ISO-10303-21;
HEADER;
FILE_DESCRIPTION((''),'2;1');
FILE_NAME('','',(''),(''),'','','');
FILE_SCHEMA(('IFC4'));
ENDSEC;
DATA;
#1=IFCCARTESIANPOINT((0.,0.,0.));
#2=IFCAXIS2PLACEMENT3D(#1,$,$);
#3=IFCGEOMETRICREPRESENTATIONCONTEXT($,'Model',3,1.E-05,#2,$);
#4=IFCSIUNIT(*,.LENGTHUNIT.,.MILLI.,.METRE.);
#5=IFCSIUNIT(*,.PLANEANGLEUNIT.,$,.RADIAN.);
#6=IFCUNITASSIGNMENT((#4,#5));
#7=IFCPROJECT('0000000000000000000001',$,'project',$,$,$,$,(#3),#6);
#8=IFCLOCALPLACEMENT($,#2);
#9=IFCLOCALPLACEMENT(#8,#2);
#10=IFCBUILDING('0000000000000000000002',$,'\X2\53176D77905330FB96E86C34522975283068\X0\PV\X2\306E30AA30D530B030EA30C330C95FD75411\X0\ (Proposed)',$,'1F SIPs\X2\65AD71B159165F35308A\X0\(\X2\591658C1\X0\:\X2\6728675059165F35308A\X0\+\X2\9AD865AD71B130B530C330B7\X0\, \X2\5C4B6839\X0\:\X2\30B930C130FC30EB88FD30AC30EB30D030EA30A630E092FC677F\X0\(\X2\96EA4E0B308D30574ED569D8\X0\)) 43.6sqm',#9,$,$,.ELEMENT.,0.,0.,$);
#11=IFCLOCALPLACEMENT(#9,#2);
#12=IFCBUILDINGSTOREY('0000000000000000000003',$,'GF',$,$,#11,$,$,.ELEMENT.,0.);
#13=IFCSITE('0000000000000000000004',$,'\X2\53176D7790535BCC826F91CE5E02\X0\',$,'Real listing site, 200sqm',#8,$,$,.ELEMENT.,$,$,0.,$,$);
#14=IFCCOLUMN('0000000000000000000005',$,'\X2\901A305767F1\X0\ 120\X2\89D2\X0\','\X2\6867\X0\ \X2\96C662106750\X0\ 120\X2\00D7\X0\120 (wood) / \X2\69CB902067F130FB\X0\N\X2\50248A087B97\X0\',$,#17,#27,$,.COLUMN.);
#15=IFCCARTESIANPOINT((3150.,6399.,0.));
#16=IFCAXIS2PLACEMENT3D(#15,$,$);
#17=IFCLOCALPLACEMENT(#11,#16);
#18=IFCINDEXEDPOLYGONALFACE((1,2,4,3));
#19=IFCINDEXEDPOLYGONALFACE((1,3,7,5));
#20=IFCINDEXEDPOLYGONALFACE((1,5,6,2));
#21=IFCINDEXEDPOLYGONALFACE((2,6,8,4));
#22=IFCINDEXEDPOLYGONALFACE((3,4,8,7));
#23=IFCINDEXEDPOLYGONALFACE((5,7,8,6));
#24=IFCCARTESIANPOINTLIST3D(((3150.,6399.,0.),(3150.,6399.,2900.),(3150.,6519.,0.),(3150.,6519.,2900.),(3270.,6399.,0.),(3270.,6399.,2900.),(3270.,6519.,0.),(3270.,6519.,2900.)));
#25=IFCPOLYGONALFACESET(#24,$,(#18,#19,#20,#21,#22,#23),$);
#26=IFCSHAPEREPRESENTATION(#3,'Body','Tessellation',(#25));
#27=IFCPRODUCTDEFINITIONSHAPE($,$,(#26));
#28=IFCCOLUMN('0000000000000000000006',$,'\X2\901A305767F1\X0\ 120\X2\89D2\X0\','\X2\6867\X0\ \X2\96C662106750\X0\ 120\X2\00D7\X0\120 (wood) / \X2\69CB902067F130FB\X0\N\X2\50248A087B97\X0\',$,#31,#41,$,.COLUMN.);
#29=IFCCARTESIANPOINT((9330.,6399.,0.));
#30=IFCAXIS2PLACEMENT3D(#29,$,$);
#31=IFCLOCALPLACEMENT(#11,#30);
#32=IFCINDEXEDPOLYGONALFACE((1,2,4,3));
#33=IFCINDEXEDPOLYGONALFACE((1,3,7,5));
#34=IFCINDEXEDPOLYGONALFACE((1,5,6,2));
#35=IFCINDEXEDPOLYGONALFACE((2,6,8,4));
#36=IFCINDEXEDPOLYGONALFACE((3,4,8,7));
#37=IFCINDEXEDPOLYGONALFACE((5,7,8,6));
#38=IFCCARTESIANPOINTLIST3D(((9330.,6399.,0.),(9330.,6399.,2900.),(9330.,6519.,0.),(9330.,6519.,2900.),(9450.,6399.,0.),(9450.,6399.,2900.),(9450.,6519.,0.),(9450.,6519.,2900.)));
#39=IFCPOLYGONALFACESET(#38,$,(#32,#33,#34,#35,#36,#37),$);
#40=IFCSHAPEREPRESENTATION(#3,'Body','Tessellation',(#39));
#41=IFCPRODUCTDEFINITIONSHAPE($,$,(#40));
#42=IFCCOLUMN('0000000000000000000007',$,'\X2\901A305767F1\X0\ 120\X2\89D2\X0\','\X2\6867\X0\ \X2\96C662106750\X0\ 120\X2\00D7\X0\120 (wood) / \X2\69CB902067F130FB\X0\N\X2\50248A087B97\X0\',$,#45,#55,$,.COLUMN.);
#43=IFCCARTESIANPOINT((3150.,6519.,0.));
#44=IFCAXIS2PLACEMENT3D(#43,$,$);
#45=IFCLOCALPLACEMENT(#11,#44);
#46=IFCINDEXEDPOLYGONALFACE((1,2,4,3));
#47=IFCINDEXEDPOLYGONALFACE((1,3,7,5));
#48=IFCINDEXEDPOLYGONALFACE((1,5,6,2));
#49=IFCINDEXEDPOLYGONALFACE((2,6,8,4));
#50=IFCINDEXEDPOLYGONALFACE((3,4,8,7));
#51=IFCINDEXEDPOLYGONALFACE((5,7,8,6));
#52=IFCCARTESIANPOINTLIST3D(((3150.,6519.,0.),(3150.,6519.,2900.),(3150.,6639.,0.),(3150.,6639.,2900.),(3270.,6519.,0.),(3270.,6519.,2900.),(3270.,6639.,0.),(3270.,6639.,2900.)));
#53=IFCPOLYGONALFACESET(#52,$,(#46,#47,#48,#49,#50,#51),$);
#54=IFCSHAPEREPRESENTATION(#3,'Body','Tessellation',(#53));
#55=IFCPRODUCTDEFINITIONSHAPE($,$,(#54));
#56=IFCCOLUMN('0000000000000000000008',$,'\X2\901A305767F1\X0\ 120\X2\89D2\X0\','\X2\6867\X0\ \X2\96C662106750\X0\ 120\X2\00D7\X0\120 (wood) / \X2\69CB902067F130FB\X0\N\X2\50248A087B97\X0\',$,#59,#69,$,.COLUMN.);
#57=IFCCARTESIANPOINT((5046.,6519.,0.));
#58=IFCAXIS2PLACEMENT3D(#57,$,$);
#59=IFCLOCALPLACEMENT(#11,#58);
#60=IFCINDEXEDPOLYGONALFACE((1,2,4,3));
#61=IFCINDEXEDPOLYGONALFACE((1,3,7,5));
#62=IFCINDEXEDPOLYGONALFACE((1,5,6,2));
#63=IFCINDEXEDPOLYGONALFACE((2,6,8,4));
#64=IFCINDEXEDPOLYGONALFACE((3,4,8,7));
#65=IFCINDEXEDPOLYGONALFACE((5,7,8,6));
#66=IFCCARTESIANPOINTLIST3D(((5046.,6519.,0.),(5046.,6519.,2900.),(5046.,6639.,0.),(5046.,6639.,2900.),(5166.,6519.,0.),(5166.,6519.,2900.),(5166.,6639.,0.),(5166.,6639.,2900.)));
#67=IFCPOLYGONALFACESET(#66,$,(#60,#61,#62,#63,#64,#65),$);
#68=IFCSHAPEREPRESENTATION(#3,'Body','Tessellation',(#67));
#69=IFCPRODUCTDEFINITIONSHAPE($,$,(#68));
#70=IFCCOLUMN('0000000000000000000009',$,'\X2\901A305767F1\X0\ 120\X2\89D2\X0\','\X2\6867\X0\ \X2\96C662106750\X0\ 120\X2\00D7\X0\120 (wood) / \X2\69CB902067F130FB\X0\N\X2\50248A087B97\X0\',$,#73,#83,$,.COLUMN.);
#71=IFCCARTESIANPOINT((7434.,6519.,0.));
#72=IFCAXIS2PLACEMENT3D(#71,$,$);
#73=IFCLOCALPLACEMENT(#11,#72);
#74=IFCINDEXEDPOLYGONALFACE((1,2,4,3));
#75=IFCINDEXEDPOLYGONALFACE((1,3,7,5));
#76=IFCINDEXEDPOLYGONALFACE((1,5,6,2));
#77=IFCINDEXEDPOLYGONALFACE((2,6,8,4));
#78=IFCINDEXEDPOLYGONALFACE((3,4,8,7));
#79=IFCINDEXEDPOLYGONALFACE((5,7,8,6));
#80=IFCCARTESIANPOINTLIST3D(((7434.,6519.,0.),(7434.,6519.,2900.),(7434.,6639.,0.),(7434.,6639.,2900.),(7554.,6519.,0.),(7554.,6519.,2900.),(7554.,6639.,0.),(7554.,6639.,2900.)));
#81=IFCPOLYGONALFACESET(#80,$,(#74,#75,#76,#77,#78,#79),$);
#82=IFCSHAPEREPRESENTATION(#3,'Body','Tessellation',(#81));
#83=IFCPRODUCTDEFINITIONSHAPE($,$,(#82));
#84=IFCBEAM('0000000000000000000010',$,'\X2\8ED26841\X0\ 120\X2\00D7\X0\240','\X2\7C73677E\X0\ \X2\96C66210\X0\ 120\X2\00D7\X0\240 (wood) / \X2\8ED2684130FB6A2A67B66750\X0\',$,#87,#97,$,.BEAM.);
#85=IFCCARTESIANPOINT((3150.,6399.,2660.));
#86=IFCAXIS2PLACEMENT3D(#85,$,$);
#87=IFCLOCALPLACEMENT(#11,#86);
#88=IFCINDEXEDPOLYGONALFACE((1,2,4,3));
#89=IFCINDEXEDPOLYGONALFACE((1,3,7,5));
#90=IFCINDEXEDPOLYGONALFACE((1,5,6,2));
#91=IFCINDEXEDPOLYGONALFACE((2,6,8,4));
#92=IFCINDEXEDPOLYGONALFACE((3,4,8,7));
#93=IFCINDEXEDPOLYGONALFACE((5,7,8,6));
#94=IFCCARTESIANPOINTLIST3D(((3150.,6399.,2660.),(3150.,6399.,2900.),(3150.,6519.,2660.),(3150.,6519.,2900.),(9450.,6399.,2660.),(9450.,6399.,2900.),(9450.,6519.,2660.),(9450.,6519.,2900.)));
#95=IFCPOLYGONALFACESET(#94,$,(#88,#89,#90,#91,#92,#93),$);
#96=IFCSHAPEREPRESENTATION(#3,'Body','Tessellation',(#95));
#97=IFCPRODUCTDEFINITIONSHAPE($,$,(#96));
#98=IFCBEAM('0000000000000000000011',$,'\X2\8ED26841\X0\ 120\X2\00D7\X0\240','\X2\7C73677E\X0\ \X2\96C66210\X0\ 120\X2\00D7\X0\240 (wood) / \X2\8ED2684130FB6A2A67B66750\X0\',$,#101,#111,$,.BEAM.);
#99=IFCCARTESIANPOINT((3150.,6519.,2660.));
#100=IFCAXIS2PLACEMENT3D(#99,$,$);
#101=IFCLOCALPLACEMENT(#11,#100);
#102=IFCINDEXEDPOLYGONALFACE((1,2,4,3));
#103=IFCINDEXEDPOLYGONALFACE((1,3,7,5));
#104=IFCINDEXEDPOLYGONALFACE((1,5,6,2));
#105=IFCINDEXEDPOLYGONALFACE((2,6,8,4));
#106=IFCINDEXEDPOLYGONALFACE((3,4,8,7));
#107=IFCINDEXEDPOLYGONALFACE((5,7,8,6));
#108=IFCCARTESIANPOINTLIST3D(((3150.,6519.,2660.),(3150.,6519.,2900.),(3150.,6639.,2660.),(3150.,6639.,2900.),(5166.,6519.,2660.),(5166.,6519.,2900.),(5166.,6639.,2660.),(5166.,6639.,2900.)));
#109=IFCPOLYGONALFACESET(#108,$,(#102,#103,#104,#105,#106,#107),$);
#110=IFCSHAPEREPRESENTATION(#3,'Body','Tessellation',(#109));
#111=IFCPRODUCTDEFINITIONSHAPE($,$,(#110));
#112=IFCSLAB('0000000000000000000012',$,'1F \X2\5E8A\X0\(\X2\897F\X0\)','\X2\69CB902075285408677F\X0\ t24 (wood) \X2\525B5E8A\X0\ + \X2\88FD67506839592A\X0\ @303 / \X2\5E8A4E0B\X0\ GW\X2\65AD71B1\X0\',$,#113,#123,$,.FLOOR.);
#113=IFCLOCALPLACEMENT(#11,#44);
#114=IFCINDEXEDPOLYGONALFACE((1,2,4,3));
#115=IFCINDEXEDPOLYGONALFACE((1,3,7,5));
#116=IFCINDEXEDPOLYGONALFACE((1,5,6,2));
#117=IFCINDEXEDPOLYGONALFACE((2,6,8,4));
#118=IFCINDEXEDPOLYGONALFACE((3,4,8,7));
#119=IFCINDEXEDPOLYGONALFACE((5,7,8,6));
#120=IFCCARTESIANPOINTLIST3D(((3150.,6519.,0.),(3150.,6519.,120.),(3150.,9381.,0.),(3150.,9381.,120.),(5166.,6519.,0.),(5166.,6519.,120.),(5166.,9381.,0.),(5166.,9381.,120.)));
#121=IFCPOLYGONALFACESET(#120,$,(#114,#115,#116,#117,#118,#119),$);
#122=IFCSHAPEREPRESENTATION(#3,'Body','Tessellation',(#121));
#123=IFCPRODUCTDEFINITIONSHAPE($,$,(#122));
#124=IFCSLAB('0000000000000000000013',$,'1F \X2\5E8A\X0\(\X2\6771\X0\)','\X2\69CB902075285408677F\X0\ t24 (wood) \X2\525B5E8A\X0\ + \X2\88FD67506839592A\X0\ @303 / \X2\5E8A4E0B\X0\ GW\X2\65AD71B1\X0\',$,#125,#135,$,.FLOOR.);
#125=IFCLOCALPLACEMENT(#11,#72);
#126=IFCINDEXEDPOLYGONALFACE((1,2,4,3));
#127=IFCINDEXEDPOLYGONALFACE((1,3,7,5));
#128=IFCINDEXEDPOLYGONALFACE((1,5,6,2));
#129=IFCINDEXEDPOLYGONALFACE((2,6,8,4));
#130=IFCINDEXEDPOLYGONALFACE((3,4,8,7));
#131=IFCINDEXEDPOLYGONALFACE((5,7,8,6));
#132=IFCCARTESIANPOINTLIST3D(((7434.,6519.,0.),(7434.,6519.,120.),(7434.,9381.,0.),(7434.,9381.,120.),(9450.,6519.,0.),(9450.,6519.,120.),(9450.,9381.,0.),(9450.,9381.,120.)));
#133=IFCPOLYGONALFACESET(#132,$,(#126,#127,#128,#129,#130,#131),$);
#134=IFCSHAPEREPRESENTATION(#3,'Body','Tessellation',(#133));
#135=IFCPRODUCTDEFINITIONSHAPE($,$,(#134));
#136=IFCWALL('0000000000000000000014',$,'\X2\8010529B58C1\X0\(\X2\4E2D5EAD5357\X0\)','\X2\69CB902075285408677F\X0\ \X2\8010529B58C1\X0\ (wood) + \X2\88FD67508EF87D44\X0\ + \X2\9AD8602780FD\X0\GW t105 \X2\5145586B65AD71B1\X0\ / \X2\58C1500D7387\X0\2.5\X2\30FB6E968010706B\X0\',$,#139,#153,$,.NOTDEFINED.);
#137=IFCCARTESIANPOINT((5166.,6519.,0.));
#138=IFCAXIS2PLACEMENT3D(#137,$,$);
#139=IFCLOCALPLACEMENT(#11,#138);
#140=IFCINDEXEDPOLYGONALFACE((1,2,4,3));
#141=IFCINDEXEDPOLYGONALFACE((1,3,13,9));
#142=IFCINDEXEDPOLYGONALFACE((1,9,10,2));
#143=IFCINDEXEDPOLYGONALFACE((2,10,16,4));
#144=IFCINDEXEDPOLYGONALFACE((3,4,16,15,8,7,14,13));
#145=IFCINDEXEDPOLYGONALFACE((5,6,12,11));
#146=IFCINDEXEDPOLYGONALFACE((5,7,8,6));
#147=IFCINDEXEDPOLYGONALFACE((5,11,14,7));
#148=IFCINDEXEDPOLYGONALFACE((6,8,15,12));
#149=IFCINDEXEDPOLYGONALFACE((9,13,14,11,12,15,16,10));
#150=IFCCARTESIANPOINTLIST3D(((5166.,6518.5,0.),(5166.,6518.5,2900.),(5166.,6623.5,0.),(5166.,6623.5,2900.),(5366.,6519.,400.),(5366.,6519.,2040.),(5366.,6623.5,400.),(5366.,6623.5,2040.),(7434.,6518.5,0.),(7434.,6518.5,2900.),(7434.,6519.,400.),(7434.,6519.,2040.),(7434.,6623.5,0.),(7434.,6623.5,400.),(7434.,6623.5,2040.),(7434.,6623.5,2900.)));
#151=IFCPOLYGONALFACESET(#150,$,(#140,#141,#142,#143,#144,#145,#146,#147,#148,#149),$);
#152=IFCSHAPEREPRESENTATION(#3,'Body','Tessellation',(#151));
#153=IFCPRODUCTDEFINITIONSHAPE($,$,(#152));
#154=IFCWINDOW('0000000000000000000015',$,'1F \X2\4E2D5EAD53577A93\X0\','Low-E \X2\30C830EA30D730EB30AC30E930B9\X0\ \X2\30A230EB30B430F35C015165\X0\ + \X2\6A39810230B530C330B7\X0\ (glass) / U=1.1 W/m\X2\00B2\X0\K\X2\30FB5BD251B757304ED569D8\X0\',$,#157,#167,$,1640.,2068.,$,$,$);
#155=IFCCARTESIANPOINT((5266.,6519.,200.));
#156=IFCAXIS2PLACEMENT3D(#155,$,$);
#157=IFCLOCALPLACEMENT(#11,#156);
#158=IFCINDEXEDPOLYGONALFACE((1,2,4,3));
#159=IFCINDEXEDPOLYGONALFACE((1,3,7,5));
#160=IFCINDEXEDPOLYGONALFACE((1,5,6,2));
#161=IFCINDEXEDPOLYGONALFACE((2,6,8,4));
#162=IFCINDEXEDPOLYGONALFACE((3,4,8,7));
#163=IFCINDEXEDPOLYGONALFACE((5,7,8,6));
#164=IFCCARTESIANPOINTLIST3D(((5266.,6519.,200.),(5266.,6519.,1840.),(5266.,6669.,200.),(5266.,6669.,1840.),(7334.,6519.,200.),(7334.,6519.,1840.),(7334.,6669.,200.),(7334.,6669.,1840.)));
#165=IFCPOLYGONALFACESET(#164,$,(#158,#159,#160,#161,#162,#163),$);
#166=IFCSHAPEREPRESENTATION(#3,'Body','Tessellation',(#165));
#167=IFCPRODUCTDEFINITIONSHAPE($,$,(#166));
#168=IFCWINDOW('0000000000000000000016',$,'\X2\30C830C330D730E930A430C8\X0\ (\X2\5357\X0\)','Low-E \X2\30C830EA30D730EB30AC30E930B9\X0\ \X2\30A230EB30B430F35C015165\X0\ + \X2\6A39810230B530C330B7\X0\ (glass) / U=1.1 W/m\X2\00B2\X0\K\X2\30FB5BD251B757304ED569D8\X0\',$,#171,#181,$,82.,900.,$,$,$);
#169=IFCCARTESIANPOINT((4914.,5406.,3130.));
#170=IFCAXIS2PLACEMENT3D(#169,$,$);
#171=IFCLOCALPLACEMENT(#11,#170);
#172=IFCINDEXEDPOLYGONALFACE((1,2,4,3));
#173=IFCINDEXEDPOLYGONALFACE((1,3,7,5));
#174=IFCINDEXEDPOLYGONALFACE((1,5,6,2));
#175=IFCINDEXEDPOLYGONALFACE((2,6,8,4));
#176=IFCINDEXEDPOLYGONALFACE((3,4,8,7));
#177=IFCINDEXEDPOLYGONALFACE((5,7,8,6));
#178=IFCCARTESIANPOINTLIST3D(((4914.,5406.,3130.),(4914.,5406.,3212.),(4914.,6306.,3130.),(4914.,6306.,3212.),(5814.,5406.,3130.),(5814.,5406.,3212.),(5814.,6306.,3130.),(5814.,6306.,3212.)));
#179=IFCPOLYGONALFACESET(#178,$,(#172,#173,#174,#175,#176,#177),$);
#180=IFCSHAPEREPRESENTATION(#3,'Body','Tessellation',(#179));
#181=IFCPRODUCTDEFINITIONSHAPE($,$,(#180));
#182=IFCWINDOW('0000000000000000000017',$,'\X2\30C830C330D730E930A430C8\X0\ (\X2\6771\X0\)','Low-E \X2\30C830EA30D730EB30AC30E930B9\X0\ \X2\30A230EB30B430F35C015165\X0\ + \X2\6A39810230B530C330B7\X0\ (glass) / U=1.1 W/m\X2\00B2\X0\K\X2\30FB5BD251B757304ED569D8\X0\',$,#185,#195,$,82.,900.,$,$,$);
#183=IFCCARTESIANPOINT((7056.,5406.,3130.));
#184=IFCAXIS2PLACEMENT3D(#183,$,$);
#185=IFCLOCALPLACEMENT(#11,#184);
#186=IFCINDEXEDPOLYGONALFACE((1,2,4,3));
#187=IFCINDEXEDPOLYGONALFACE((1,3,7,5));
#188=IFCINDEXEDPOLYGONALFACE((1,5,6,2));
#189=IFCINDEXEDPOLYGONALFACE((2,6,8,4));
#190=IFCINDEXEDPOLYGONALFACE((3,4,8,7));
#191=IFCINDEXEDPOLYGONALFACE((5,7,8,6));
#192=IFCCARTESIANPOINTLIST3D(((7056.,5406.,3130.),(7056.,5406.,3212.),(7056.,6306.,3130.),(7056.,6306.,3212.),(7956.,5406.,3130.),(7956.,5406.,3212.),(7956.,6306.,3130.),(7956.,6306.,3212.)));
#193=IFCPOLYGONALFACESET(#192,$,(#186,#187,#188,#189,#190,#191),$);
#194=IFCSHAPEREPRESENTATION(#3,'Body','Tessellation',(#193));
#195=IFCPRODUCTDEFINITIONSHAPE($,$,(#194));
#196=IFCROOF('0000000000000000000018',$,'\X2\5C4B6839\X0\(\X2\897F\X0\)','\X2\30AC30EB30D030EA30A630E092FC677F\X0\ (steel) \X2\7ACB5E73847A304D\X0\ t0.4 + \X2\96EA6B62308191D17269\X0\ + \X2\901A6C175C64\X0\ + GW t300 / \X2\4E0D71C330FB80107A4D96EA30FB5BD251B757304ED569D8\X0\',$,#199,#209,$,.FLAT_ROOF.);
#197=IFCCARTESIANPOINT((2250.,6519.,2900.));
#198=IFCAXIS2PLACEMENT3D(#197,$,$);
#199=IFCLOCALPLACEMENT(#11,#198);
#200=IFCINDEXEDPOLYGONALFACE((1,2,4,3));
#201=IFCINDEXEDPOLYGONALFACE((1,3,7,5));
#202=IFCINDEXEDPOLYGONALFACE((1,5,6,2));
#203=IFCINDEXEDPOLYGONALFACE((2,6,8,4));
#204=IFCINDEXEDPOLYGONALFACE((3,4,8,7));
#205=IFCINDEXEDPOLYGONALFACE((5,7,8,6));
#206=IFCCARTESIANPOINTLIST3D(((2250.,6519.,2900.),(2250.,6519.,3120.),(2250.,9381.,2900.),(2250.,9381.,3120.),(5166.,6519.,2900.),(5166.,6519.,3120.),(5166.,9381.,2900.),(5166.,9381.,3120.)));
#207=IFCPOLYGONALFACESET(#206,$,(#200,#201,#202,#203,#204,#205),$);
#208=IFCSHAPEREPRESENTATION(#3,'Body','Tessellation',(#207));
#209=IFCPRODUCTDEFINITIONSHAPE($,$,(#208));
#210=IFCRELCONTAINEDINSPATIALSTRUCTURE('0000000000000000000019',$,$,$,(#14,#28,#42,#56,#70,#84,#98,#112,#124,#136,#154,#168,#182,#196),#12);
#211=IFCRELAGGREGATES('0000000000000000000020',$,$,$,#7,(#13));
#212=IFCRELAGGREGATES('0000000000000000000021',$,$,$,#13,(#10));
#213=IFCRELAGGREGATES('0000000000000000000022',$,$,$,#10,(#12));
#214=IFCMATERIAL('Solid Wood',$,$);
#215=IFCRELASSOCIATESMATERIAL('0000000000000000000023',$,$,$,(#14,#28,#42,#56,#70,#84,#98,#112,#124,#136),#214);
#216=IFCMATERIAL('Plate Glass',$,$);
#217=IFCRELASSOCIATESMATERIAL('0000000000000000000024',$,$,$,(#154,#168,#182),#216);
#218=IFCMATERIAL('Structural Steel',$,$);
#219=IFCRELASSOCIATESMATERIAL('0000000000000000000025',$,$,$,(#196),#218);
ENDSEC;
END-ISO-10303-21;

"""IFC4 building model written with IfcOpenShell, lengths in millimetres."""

from ifc_helpers import new_model, si_unit, frame, frame_2d, origin, place, context, project, spatial, rectangle, extrude, material, element, fill, save


model = new_model("IFC4")

# Units and contexts
model_context = context("Model", 3, precision=1e-05, world=origin())
ifc_project = project(units=[si_unit("LENGTHUNIT", "METRE", prefix="MILLI"), si_unit("PLANEANGLEUNIT", "RADIAN")], contexts=[model_context])

# Site, building, storey
site_placement = place(None, origin())
site = spatial("IfcSite", under=ifc_project, at=site_placement, Name="北海道富良野市", ObjectType="Real listing site, 200sqm", CompositionType="ELEMENT", RefElevation=0.0)
building_placement = place(site_placement, origin())
building = spatial("IfcBuilding", under=site, at=building_placement, Name="北海道・雨水利用とPVのオフグリッド志向 (Proposed)", ObjectType="1F SIPs断熱外張り(外壁:木材外張り+高断熱サッシ, 屋根:スチール製ガルバリウム鋼板(雪下ろし仕様)) 43.6sqm", CompositionType="ELEMENT", ElevationOfRefHeight=0.0, ElevationOfTerrain=0.0)
storey_placement = place(building_placement, origin())
storey = spatial("IfcBuildingStorey", under=building, at=storey_placement, Name="GF", CompositionType="ELEMENT", Elevation=0.0)

# Columns
ifc_material_1 = material(Name="Solid Wood")
column_1_placement = place(storey_placement, frame((3150.0, 6399.0, 0.0)))
element("IfcColumn", 1, at=column_1_placement, inside=storey, material=ifc_material_1, Name="通し柱 120角", Description="桧 集成材 120×120 (wood) / 構造柱・N値計算", PredefinedType="COLUMN", context=model_context, shape_type="SweptSolid", body=[
    extrude(rectangle(XDim=120.0, YDim=120.0, at=frame_2d((60.0, 60.0))), frame((3150.0, 6399.0, 0.0)), (0.0, 0.0, 1.0), 2900.0),
])
column_2_placement = place(storey_placement, frame((9330.0, 6399.0, 0.0)))
element("IfcColumn", 2, at=column_2_placement, inside=storey, material=ifc_material_1, Name="通し柱 120角", Description="桧 集成材 120×120 (wood) / 構造柱・N値計算", PredefinedType="COLUMN", context=model_context, shape_type="SweptSolid", body=[
    extrude(rectangle(XDim=120.0, YDim=120.0, at=frame_2d((60.0, 60.0))), frame((9330.0, 6399.0, 0.0)), (0.0, 0.0, 1.0), 2900.0),
])
column_3_placement = place(storey_placement, frame((3150.0, 6519.0, 0.0)))
element("IfcColumn", 3, at=column_3_placement, inside=storey, material=ifc_material_1, Name="通し柱 120角", Description="桧 集成材 120×120 (wood) / 構造柱・N値計算", PredefinedType="COLUMN", context=model_context, shape_type="SweptSolid", body=[
    extrude(rectangle(XDim=120.0, YDim=120.0, at=frame_2d((60.0, 60.0))), frame((3150.0, 6519.0, 0.0)), (0.0, 0.0, 1.0), 2900.0),
])
column_4_placement = place(storey_placement, frame((5046.0, 6519.0, 0.0)))
element("IfcColumn", 4, at=column_4_placement, inside=storey, material=ifc_material_1, Name="通し柱 120角", Description="桧 集成材 120×120 (wood) / 構造柱・N値計算", PredefinedType="COLUMN", context=model_context, shape_type="SweptSolid", body=[
    extrude(rectangle(XDim=120.0, YDim=120.0, at=frame_2d((60.0, 60.0))), frame((5046.0, 6519.0, 0.0)), (0.0, 0.0, 1.0), 2900.0),
])
column_5_placement = place(storey_placement, frame((7434.0, 6519.0, 0.0)))
element("IfcColumn", 5, at=column_5_placement, inside=storey, material=ifc_material_1, Name="通し柱 120角", Description="桧 集成材 120×120 (wood) / 構造柱・N値計算", PredefinedType="COLUMN", context=model_context, shape_type="SweptSolid", body=[
    extrude(rectangle(XDim=120.0, YDim=120.0, at=frame_2d((60.0, 60.0))), frame((7434.0, 6519.0, 0.0)), (0.0, 0.0, 1.0), 2900.0),
])

# Beams
beam_1_placement = place(storey_placement, frame((3150.0, 6399.0, 2660.0)))
element("IfcBeam", 6, at=beam_1_placement, inside=storey, material=ifc_material_1, Name="軒桁 120×240", Description="米松 集成 120×240 (wood) / 軒桁・横架材", PredefinedType="BEAM", context=model_context, shape_type="SweptSolid", body=[
    extrude(rectangle(XDim=6300.0, YDim=120.0, at=frame_2d((3150.0, 60.0))), frame((3150.0, 6399.0, 2660.0)), (0.0, 0.0, 1.0), 240.0),
])
beam_2_placement = place(storey_placement, frame((3150.0, 6519.0, 2660.0)))
element("IfcBeam", 7, at=beam_2_placement, inside=storey, material=ifc_material_1, Name="軒桁 120×240", Description="米松 集成 120×240 (wood) / 軒桁・横架材", PredefinedType="BEAM", context=model_context, shape_type="SweptSolid", body=[
    extrude(rectangle(XDim=2016.0, YDim=120.0, at=frame_2d((1008.0, 60.0))), frame((3150.0, 6519.0, 2660.0)), (0.0, 0.0, 1.0), 240.0),
])

# Slabs
slab_1_placement = place(storey_placement, frame((3150.0, 6519.0, 0.0)))
element("IfcSlab", 8, at=slab_1_placement, inside=storey, material=ifc_material_1, Name="1F 床(西)", Description="構造用合板 t24 (wood) 剛床 + 製材根太 @303 / 床下 GW断熱", PredefinedType="FLOOR", context=model_context, shape_type="SweptSolid", body=[
    extrude(rectangle(XDim=2016.0, YDim=2862.0, at=frame_2d((1008.0, 1431.0))), frame((3150.0, 6519.0, 0.0)), (0.0, 0.0, 1.0), 120.0),
])
slab_2_placement = place(storey_placement, frame((7434.0, 6519.0, 0.0)))
element("IfcSlab", 9, at=slab_2_placement, inside=storey, material=ifc_material_1, Name="1F 床(東)", Description="構造用合板 t24 (wood) 剛床 + 製材根太 @303 / 床下 GW断熱", PredefinedType="FLOOR", context=model_context, shape_type="SweptSolid", body=[
    extrude(rectangle(XDim=2016.0, YDim=2862.0, at=frame_2d((1008.0, 1431.0))), frame((7434.0, 6519.0, 0.0)), (0.0, 0.0, 1.0), 120.0),
])

# Wall, opening, window
wall_1_placement = place(storey_placement, frame((5166.0, 6519.0, 0.0)))
wall_1 = element("IfcWall", 10, at=wall_1_placement, inside=storey, material=ifc_material_1, Name="耐力壁(中庭南)", Description="構造用合板 耐力壁 (wood) + 製材軸組 + 高性能GW t105 充填断熱 / 壁倍率2.5・準耐火", PredefinedType="NOTDEFINED", context=model_context, shape_type="SweptSolid", body=[
    extrude(rectangle(XDim=2268.0, YDim=105.0, at=frame_2d((1134.0, 52.0))), frame((5166.0, 6519.0, 0.0)), (0.0, 0.0, 1.0), 2900.0),
])
opening_placement = place(storey_placement, frame((5266.0, 6519.0, 200.0)))
opening = element("IfcOpeningElement", 11, at=opening_placement, cuts=wall_1, PredefinedType="NOTDEFINED", context=model_context, shape_type="SweptSolid", body=[
    extrude(rectangle(XDim=2068.0, YDim=150.0, at=frame_2d((1034.0, 75.0))), frame((5266.0, 6519.0, 200.0)), (0.0, 0.0, 1.0), 1640.0),
])
ifc_material_2 = material(Name="Plate Glass")
window_1_placement = place(storey_placement, frame((5266.0, 6519.0, 200.0)))
window_1 = element("IfcWindow", 12, at=window_1_placement, inside=storey, material=ifc_material_2, Name="1F 中庭南窓", Description="Low-E トリプルガラス アルゴン封入 + 樹脂サッシ (glass) / U=1.1 W/m²K・寒冷地仕様", OverallHeight=1640.0, OverallWidth=2068.0, context=model_context, shape_type="SweptSolid", body=[
    extrude(rectangle(XDim=2068.0, YDim=150.0, at=frame_2d((1034.0, 75.0))), frame((5266.0, 6519.0, 200.0)), (0.0, 0.0, 1.0), 1640.0),
])
fill(opening, window_1)

# Windows
window_2_placement = place(storey_placement, frame((4914.0, 5406.0, 3130.0)))
element("IfcWindow", 13, at=window_2_placement, inside=storey, material=ifc_material_2, Name="トップライト (南)", Description="Low-E トリプルガラス アルゴン封入 + 樹脂サッシ (glass) / U=1.1 W/m²K・寒冷地仕様", OverallHeight=82.0, OverallWidth=900.0, context=model_context, shape_type="SweptSolid", body=[
    extrude(rectangle(XDim=900.0, YDim=900.0, at=frame_2d((450.0, 450.0))), frame((4914.0, 5406.0, 3130.0)), (0.0, 0.0, 1.0), 82.0),
])
window_3_placement = place(storey_placement, frame((7056.0, 5406.0, 3130.0)))
element("IfcWindow", 14, at=window_3_placement, inside=storey, material=ifc_material_2, Name="トップライト (東)", Description="Low-E トリプルガラス アルゴン封入 + 樹脂サッシ (glass) / U=1.1 W/m²K・寒冷地仕様", OverallHeight=82.0, OverallWidth=900.0, context=model_context, shape_type="SweptSolid", body=[
    extrude(rectangle(XDim=900.0, YDim=900.0, at=frame_2d((450.0, 450.0))), frame((7056.0, 5406.0, 3130.0)), (0.0, 0.0, 1.0), 82.0),
])

# Roof
ifc_material_3 = material(Name="Structural Steel")
roof_1_placement = place(storey_placement, frame((2250.0, 6519.0, 2900.0)))
element("IfcRoof", 15, at=roof_1_placement, inside=storey, material=ifc_material_3, Name="屋根(西)", Description="ガルバリウム鋼板 (steel) 立平葺き t0.4 + 雪止め金物 + 通気層 + GW t300 / 不燃・耐積雪・寒冷地仕様", PredefinedType="FLAT_ROOF", context=model_context, shape_type="SweptSolid", body=[
    extrude(rectangle(XDim=2916.0, YDim=2862.0, at=frame_2d((1458.0, 1431.0))), frame((2250.0, 6519.0, 2900.0)), (0.0, 0.0, 1.0), 220.0),
])

save(model, "model.ifc")
